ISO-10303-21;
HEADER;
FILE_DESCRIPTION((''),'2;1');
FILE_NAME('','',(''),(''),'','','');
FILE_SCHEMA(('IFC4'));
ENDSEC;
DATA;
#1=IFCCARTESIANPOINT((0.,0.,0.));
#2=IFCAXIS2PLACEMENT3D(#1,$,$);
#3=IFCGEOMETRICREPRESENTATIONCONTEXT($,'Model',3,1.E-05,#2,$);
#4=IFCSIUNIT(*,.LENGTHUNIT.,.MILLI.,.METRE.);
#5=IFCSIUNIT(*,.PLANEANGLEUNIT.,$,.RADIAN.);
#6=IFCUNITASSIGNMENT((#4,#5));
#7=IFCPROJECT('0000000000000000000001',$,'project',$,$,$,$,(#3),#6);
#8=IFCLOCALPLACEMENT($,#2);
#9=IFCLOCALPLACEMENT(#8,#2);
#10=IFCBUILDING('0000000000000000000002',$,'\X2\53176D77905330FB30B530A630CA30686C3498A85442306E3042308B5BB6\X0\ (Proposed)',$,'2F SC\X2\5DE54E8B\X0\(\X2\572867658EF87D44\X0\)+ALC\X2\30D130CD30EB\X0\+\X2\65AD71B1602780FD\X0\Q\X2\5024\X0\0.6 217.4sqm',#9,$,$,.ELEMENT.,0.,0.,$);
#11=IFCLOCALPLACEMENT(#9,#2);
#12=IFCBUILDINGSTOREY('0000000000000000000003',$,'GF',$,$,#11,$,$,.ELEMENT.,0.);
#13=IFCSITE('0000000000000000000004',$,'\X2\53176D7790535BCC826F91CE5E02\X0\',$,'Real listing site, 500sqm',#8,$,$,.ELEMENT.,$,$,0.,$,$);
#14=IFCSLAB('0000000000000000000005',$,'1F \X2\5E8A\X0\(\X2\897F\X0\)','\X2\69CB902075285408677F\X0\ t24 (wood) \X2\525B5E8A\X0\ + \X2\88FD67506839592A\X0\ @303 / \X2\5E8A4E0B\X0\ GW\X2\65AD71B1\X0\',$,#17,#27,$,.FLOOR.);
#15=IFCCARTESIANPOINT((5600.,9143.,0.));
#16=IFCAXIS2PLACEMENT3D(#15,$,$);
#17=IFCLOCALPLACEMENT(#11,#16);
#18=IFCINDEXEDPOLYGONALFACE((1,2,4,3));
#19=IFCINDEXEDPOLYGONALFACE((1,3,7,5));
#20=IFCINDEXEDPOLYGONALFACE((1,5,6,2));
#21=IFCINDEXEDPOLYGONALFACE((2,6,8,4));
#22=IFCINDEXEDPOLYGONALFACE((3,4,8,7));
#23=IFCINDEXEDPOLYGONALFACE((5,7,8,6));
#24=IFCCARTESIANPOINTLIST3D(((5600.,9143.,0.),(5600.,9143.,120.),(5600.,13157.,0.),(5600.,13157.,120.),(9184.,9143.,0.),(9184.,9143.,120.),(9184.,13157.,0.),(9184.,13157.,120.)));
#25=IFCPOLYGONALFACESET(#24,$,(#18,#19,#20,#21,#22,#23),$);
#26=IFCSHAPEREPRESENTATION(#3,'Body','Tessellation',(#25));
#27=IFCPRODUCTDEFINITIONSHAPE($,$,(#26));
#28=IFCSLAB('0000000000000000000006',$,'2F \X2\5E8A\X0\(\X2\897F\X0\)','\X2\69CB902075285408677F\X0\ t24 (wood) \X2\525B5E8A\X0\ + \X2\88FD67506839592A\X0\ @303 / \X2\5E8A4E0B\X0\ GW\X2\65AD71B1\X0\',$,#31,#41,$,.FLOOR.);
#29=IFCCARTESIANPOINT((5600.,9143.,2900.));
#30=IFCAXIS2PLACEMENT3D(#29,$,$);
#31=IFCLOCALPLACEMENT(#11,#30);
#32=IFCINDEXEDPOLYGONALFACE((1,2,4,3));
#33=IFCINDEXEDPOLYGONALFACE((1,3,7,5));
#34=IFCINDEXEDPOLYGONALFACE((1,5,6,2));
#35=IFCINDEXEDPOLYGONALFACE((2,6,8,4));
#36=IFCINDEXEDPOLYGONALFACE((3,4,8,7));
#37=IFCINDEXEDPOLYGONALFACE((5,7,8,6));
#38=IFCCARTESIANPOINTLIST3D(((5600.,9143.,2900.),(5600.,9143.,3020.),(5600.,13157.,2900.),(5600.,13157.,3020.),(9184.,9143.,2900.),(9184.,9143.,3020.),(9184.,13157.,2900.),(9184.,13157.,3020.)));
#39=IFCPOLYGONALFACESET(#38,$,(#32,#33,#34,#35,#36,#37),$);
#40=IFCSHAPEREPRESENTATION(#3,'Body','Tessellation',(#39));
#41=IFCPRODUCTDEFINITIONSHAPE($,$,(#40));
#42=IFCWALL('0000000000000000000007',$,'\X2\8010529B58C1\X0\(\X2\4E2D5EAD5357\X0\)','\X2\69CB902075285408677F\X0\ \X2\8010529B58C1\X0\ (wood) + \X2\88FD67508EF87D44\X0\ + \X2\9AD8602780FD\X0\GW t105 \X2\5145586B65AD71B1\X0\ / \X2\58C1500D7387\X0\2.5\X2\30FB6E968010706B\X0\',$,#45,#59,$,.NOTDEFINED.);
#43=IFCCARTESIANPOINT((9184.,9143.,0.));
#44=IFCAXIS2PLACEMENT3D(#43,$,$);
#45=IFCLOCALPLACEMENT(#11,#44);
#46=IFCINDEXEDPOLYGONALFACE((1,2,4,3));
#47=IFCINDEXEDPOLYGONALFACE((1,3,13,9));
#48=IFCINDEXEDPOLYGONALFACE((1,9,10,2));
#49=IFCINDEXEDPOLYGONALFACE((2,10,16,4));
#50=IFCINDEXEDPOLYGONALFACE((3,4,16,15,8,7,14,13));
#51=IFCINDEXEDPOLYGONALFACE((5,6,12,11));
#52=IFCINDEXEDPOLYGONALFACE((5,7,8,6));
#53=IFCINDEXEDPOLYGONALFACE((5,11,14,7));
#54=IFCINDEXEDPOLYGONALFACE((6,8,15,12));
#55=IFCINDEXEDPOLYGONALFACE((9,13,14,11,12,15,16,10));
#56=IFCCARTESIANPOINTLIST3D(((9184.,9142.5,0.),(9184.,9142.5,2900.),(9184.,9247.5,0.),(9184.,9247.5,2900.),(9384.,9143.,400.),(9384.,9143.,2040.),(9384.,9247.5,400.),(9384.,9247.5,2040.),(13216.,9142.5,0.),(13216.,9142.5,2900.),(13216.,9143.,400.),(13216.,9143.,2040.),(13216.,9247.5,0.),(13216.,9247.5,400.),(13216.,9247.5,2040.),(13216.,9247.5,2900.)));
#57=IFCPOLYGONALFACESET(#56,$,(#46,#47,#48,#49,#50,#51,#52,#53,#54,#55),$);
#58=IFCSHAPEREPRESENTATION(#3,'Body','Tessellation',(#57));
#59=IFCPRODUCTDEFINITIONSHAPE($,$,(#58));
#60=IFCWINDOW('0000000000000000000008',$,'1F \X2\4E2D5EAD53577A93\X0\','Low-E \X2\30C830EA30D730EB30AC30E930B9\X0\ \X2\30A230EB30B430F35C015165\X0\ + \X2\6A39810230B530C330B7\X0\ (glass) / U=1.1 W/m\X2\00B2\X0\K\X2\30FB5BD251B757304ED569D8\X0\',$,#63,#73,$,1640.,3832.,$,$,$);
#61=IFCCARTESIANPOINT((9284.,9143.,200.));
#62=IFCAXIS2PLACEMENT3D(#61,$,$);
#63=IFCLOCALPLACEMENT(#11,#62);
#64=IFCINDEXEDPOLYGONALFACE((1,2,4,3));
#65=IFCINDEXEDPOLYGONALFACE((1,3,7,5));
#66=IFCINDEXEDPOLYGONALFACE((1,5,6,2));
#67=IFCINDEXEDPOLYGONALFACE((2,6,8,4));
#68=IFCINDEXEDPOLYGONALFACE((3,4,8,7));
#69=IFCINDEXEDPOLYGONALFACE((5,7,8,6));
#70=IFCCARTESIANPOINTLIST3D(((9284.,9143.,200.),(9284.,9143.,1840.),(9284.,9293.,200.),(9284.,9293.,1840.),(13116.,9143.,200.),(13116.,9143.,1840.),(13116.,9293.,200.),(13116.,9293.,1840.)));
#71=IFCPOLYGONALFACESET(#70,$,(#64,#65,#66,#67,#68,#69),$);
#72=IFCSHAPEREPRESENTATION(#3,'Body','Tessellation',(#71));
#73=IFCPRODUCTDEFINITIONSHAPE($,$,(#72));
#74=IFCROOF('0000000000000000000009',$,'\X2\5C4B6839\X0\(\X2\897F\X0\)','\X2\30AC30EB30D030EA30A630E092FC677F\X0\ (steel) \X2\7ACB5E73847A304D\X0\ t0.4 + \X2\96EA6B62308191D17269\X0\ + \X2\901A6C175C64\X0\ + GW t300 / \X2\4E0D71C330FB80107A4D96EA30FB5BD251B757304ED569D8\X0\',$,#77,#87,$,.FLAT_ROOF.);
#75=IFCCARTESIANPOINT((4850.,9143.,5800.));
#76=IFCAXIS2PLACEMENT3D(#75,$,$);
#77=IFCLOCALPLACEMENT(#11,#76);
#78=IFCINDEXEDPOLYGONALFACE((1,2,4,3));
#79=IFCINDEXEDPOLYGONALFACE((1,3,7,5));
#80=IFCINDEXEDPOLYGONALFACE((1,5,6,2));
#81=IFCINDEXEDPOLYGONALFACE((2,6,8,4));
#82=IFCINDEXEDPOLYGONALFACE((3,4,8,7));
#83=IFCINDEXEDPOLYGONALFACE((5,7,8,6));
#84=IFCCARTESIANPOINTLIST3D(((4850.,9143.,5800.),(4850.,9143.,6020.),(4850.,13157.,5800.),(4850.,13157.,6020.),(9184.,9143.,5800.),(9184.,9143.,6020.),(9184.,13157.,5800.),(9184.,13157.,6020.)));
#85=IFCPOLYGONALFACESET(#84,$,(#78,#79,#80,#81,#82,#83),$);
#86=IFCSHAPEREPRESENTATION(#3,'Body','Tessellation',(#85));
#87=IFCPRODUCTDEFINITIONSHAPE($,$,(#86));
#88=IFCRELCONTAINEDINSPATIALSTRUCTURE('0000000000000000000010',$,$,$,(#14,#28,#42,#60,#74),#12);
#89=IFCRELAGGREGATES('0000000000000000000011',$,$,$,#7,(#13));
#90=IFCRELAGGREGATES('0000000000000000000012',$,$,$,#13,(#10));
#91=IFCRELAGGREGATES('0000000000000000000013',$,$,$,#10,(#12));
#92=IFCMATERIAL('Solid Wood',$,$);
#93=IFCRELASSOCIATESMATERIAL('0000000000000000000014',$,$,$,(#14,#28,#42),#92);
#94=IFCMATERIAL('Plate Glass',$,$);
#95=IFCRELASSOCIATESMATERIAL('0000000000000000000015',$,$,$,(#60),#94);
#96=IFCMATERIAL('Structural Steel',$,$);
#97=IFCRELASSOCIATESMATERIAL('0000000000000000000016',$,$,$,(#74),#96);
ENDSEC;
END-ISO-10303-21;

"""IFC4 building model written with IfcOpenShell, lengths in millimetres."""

from ifc_helpers import new_model, si_unit, frame, frame_2d, origin, place, context, project, spatial, rectangle, extrude, material, element, fill, save


model = new_model("IFC4")

# Units and contexts
model_context = context("Model", 3, precision=1e-05, world=origin())
ifc_project = project(units=[si_unit("LENGTHUNIT", "METRE", prefix="MILLI"), si_unit("PLANEANGLEUNIT", "RADIAN")], contexts=[model_context])

# Site, building, storey
site_placement = place(None, origin())
site = spatial("IfcSite", under=ifc_project, at=site_placement, Name="北海道富良野市", ObjectType="Real listing site, 500sqm", CompositionType="ELEMENT", RefElevation=0.0)
building_placement = place(site_placement, origin())
building = spatial("IfcBuilding", under=site, at=building_placement, Name="北海道・サウナと水風呂のある家 (Proposed)", ObjectType="2F SC工事(在来軸組)+ALCパネル+断熱性能Q値0.6 217.4sqm", CompositionType="ELEMENT", ElevationOfRefHeight=0.0, ElevationOfTerrain=0.0)
storey_placement = place(building_placement, origin())
storey = spatial("IfcBuildingStorey", under=building, at=storey_placement, Name="GF", CompositionType="ELEMENT", Elevation=0.0)

# Shared definitions
ifc_material_1 = material(Name="Solid Wood")

# Slabs
slab_1_placement = place(storey_placement, frame((5600.0, 9143.0, 0.0)))
element("IfcSlab", 1, at=slab_1_placement, inside=storey, material=ifc_material_1, Name="1F 床(西)", Description="構造用合板 t24 (wood) 剛床 + 製材根太 @303 / 床下 GW断熱", PredefinedType="FLOOR", context=model_context, shape_type="SweptSolid", body=[
    extrude(rectangle(XDim=3584.0, YDim=4014.0, at=frame_2d((1792.0, 2007.0))), frame((5600.0, 9143.0, 0.0)), (0.0, 0.0, 1.0), 120.0),
])
slab_2_placement = place(storey_placement, frame((5600.0, 9143.0, 2900.0)))
element("IfcSlab", 2, at=slab_2_placement, inside=storey, material=ifc_material_1, Name="2F 床(西)", Description="構造用合板 t24 (wood) 剛床 + 製材根太 @303 / 床下 GW断熱", PredefinedType="FLOOR", context=model_context, shape_type="SweptSolid", body=[
    extrude(rectangle(XDim=3584.0, YDim=4014.0, at=frame_2d((1792.0, 2007.0))), frame((5600.0, 9143.0, 2900.0)), (0.0, 0.0, 1.0), 120.0),
])

# Wall, opening, window
wall_placement = place(storey_placement, frame((9184.0, 9143.0, 0.0)))
wall = element("IfcWall", 3, at=wall_placement, inside=storey, material=ifc_material_1, Name="耐力壁(中庭南)", Description="構造用合板 耐力壁 (wood) + 製材軸組 + 高性能GW t105 充填断熱 / 壁倍率2.5・準耐火", PredefinedType="NOTDEFINED", context=model_context, shape_type="SweptSolid", body=[
    extrude(rectangle(XDim=4032.0, YDim=105.0, at=frame_2d((2016.0, 52.0))), frame((9184.0, 9143.0, 0.0)), (0.0, 0.0, 1.0), 2900.0),
])
opening_placement = place(storey_placement, frame((9284.0, 9143.0, 200.0)))
opening = element("IfcOpeningElement", 4, at=opening_placement, cuts=wall, PredefinedType="NOTDEFINED", context=model_context, shape_type="SweptSolid", body=[
    extrude(rectangle(XDim=3832.0, YDim=150.0, at=frame_2d((1916.0, 75.0))), frame((9284.0, 9143.0, 200.0)), (0.0, 0.0, 1.0), 1640.0),
])
ifc_material_2 = material(Name="Plate Glass")
window_placement = place(storey_placement, frame((9284.0, 9143.0, 200.0)))
window = element("IfcWindow", 5, at=window_placement, inside=storey, material=ifc_material_2, Name="1F 中庭南窓", Description="Low-E トリプルガラス アルゴン封入 + 樹脂サッシ (glass) / U=1.1 W/m²K・寒冷地仕様", OverallHeight=1640.0, OverallWidth=3832.0, context=model_context, shape_type="SweptSolid", body=[
    extrude(rectangle(XDim=3832.0, YDim=150.0, at=frame_2d((1916.0, 75.0))), frame((9284.0, 9143.0, 200.0)), (0.0, 0.0, 1.0), 1640.0),
])
fill(opening, window)

# Roof
ifc_material_3 = material(Name="Structural Steel")
for number, where, name in (
    (6, (4850.0, 9143.0, 5800.0), "屋根(西)"),
):
    element("IfcRoof", number, at=place(storey_placement, frame(where)), inside=storey, material=ifc_material_3, Name=name, Description="ガルバリウム鋼板 (steel) 立平葺き t0.4 + 雪止め金物 + 通気層 + GW t300 / 不燃・耐積雪・寒冷地仕様", PredefinedType="FLAT_ROOF", context=model_context, shape_type="SweptSolid", body=[
        extrude(rectangle(XDim=4334.0, YDim=4014.0, at=frame_2d((2167.0, 2007.0))), frame((4850.0, 9143.0, 5800.0)), (0.0, 0.0, 1.0), 220.0),
    ])

save(model, "model.ifc")
